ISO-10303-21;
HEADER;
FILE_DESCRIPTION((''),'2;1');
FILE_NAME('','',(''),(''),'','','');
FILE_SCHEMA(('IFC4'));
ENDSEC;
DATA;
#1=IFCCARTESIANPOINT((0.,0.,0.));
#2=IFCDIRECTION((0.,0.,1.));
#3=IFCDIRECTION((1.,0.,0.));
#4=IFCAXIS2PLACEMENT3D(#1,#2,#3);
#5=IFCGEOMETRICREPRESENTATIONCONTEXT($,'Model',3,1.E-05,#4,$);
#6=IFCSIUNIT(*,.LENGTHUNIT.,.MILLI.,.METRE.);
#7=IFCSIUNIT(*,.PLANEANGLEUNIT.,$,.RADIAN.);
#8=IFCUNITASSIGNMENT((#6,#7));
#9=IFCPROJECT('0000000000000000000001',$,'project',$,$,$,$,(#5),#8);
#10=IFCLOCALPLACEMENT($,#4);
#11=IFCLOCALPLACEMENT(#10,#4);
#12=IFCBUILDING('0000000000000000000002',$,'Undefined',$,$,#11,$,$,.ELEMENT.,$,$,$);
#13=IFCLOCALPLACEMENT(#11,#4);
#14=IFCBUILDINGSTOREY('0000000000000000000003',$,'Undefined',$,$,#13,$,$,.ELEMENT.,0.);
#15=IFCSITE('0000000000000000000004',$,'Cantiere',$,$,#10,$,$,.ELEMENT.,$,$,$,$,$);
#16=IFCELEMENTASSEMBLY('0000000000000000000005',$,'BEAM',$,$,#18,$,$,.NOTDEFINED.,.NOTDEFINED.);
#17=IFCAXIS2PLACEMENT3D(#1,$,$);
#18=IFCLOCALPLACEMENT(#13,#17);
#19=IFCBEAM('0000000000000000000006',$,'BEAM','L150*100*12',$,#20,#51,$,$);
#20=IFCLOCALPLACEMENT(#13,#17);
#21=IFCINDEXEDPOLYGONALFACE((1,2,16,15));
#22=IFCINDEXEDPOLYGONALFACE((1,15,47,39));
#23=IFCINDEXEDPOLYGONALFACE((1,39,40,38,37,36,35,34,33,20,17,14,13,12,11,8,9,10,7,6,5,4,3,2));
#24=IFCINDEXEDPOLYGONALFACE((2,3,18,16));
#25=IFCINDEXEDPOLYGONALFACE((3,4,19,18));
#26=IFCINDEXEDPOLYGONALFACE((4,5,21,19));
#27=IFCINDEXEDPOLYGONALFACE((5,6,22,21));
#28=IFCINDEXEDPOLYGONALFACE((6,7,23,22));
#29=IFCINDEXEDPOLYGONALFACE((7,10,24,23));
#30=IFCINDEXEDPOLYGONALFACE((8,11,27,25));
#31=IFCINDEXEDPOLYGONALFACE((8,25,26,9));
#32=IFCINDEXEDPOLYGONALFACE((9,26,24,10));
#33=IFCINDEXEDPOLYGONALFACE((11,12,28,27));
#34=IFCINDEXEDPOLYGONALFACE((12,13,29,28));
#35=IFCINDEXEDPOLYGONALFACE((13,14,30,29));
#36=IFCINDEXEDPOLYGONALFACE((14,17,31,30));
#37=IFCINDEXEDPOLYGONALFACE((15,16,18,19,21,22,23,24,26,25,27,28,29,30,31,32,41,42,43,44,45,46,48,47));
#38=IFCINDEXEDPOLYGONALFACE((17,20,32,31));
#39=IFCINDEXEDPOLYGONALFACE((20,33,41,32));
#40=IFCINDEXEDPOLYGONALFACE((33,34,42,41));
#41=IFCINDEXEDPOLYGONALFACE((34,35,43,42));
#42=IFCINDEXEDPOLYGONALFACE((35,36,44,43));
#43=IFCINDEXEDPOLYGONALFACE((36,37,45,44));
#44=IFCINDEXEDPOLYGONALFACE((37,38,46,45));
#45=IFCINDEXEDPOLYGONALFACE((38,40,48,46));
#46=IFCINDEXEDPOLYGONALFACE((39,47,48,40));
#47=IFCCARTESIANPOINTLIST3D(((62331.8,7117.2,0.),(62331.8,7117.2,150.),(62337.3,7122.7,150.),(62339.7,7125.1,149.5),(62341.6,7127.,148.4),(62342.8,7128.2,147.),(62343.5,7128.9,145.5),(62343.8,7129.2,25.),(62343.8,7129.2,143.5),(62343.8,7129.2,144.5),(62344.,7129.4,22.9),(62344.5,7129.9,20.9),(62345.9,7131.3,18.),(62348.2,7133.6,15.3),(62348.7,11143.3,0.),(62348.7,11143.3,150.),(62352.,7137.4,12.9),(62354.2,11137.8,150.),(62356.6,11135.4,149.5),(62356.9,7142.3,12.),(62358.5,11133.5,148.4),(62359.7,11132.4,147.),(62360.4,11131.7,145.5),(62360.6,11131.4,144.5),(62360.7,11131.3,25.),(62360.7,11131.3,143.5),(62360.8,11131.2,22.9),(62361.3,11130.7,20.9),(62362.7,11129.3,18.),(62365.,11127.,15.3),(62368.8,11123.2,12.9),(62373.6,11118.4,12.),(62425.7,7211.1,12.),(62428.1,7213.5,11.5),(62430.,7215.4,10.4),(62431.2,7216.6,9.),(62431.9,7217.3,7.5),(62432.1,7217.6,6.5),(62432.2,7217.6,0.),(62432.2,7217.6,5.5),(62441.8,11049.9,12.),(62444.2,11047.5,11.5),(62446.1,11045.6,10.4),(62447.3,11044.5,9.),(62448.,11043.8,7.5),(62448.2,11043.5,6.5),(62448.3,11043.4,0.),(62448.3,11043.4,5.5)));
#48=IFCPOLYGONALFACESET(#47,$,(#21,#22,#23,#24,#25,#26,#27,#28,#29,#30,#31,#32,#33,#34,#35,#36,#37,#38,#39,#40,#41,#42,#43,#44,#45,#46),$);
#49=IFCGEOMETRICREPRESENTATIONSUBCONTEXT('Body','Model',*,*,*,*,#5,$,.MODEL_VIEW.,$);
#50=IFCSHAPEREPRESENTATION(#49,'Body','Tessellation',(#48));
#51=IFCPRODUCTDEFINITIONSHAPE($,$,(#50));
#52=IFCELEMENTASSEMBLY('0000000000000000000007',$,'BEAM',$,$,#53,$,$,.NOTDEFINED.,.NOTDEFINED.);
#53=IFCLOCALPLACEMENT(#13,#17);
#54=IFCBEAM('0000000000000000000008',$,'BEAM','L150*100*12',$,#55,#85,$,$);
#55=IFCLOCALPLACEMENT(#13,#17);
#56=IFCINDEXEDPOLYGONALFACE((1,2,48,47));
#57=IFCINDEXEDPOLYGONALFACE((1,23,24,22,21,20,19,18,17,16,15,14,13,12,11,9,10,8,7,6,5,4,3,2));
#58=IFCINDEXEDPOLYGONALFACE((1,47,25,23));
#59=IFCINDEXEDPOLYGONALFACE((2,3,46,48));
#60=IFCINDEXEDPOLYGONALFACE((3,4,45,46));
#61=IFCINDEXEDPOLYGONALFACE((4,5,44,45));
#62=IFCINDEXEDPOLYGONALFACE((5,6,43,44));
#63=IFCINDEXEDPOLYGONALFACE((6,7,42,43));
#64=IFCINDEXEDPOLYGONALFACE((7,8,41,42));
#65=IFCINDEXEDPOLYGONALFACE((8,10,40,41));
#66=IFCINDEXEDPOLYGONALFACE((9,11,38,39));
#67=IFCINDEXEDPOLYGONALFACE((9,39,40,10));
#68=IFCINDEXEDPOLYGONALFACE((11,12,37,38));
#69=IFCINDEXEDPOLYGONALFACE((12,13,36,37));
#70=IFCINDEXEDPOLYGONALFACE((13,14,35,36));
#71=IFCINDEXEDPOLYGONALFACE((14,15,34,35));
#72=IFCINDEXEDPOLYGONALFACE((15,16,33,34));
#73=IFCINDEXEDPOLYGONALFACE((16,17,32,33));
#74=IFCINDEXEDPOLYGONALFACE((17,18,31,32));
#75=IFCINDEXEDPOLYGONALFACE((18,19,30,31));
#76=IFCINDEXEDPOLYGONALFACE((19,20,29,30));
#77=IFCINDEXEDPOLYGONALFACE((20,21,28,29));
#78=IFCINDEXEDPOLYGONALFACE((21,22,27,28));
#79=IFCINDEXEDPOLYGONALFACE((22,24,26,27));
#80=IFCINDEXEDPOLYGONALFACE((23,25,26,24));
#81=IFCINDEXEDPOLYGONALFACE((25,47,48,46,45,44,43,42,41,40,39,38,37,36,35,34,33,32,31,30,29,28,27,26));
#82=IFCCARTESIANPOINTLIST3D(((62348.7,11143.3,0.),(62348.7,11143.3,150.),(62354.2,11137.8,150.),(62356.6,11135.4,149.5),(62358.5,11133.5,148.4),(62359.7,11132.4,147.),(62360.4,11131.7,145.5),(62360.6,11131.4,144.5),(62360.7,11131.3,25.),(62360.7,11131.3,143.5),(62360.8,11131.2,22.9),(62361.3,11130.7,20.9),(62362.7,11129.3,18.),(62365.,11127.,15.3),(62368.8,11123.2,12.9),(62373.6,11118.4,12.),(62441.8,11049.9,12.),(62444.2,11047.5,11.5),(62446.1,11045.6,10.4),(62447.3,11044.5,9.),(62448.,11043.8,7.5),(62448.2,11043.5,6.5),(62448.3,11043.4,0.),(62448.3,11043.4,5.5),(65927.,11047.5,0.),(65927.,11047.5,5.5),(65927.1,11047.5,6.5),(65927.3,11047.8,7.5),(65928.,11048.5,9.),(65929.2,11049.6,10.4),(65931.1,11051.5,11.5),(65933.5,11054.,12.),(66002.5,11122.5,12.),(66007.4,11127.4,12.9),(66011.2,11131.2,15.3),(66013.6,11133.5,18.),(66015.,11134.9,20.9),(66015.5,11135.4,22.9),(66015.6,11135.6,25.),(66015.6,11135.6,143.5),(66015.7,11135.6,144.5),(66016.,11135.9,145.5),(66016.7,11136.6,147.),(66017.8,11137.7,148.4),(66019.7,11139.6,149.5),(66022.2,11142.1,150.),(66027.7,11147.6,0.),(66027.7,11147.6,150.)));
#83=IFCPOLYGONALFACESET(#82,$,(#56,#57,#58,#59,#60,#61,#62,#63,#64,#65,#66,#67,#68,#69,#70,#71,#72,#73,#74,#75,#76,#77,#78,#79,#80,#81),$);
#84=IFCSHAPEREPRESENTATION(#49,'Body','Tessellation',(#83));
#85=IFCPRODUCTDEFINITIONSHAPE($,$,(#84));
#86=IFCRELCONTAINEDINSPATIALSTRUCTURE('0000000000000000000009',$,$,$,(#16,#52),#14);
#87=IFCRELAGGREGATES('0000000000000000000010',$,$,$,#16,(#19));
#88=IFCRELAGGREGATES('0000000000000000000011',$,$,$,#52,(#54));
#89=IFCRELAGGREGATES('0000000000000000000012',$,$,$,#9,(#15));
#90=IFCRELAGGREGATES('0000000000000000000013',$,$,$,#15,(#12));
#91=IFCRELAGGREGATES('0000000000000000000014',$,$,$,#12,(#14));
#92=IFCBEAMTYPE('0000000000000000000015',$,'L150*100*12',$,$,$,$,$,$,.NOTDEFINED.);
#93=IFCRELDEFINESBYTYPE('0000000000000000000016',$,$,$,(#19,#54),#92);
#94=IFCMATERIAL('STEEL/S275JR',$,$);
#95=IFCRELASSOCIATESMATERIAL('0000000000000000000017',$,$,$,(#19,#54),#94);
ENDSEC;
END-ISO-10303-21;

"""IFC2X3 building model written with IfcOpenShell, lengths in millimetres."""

from ifc_helpers import new_model, si_unit, frame, origin_with_axes, origin_2d_with_axis, place, context, subcontext, project, spatial, l_section, extrude, clip, halfspace, material, type_object, element, aggregate, save


model = new_model("IFC2X3")

# Units and contexts
model_context = context("Model", 3, precision=1e-05, world=origin_with_axes())
body_context = subcontext(model_context, "Body", "Model", "MODEL_VIEW")
ifc_project = project(units=[si_unit("LENGTHUNIT", "METRE", prefix="MILLI"), si_unit("PLANEANGLEUNIT", "RADIAN")], contexts=[model_context])

# Site, building, storey
site_placement = place(None, origin_with_axes())
site = spatial("IfcSite", under=ifc_project, at=site_placement, Name="Cantiere", CompositionType="ELEMENT")
building_placement = place(site_placement, origin_with_axes())
building = spatial("IfcBuilding", under=site, at=building_placement, Name="Undefined", CompositionType="ELEMENT")
storey_placement = place(building_placement, origin_with_axes())
storey = spatial("IfcBuildingStorey", under=building, at=storey_placement, Name="Undefined", CompositionType="ELEMENT", Elevation=0.0)

# Element assemblies, beams
ifc_material_1 = material(Name="STEEL/S275JR")
assembly_1_placement = place(storey_placement, origin_with_axes())
assembly_1 = element("IfcElementAssembly", 1, at=assembly_1_placement, inside=storey, Name="BEAM", AssemblyPlace="NOTDEFINED", PredefinedType="NOTDEFINED")
beam_type_1 = type_object("IfcBeamType", Name="L150*100*12", PredefinedType="NOTDEFINED")
beam_1_placement = place(assembly_1_placement, frame((62381.8, 7117.0, 75.0), z_axis=(0.0, 0.0, 1.0), x_axis=(0.004206, 0.999991, 0.0)))
beam_1 = element("IfcBeam", 2, at=beam_1_placement, type_object=beam_type_1, material=ifc_material_1, Name="BEAM", Description="L150*100*12", context=body_context, shape_type="Clipping", body=[
    clip(clip(extrude(l_section(Depth=150.0, Width=100.0, Thickness=12.0, FilletRadius=13.0, EdgeRadius=6.5, at=origin_2d_with_axis()), frame((4078.1, 0.0, 0.0), z_axis=(-1.0, 0.0, 0.0), x_axis=(0.0, -1.0, 0.0)), (0.0, 0.0, 1.0), 4129.2), halfspace(frame((3896.9, -80.0, -75.0), z_axis=(0.708998, -0.70521, 0.0), x_axis=(0.0, 0.0, 1.0)), False)), halfspace(frame((131.2, -80.0, -75.0), z_axis=(0.70398, 0.71022, 0.0), x_axis=(0.0, 0.0, 1.0)), True)),
])
aggregate(assembly_1, [beam_1])
assembly_2_placement = place(storey_placement, origin_with_axes())
assembly_2 = element("IfcElementAssembly", 3, at=assembly_2_placement, inside=storey, Name="BEAM", AssemblyPlace="NOTDEFINED", PredefinedType="NOTDEFINED")
beam_2_placement = place(assembly_2_placement, frame((62348.8, 11093.3, 75.0), z_axis=(0.0, 0.0, 1.0), x_axis=(0.999999, 0.001151, 0.0)))
beam_2 = element("IfcBeam", 4, at=beam_2_placement, type_object=beam_type_1, material=ifc_material_1, Name="BEAM", Description="L150*100*12", context=body_context, shape_type="Clipping", body=[
    clip(clip(extrude(l_section(Depth=150.0, Width=100.0, Thickness=12.0, FilletRadius=13.0, EdgeRadius=6.5, at=origin_2d_with_axis()), frame((3729.9, 0.0, 0.0), z_axis=(-1.0, 0.0, 0.0), x_axis=(0.0, -1.0, 0.0)), (0.0, 0.0, 1.0), 3781.4), halfspace(frame((3547.9, -80.0, -75.0), z_axis=(0.704083, -0.710118, 0.0), x_axis=(0.0, 0.0, 1.0)), False)), halfspace(frame((129.3, -80.0, -75.0), z_axis=(0.708998, 0.70521, 0.0), x_axis=(0.0, 0.0, 1.0)), True)),
])
aggregate(assembly_2, [beam_2])

save(model, "model.ifc")
